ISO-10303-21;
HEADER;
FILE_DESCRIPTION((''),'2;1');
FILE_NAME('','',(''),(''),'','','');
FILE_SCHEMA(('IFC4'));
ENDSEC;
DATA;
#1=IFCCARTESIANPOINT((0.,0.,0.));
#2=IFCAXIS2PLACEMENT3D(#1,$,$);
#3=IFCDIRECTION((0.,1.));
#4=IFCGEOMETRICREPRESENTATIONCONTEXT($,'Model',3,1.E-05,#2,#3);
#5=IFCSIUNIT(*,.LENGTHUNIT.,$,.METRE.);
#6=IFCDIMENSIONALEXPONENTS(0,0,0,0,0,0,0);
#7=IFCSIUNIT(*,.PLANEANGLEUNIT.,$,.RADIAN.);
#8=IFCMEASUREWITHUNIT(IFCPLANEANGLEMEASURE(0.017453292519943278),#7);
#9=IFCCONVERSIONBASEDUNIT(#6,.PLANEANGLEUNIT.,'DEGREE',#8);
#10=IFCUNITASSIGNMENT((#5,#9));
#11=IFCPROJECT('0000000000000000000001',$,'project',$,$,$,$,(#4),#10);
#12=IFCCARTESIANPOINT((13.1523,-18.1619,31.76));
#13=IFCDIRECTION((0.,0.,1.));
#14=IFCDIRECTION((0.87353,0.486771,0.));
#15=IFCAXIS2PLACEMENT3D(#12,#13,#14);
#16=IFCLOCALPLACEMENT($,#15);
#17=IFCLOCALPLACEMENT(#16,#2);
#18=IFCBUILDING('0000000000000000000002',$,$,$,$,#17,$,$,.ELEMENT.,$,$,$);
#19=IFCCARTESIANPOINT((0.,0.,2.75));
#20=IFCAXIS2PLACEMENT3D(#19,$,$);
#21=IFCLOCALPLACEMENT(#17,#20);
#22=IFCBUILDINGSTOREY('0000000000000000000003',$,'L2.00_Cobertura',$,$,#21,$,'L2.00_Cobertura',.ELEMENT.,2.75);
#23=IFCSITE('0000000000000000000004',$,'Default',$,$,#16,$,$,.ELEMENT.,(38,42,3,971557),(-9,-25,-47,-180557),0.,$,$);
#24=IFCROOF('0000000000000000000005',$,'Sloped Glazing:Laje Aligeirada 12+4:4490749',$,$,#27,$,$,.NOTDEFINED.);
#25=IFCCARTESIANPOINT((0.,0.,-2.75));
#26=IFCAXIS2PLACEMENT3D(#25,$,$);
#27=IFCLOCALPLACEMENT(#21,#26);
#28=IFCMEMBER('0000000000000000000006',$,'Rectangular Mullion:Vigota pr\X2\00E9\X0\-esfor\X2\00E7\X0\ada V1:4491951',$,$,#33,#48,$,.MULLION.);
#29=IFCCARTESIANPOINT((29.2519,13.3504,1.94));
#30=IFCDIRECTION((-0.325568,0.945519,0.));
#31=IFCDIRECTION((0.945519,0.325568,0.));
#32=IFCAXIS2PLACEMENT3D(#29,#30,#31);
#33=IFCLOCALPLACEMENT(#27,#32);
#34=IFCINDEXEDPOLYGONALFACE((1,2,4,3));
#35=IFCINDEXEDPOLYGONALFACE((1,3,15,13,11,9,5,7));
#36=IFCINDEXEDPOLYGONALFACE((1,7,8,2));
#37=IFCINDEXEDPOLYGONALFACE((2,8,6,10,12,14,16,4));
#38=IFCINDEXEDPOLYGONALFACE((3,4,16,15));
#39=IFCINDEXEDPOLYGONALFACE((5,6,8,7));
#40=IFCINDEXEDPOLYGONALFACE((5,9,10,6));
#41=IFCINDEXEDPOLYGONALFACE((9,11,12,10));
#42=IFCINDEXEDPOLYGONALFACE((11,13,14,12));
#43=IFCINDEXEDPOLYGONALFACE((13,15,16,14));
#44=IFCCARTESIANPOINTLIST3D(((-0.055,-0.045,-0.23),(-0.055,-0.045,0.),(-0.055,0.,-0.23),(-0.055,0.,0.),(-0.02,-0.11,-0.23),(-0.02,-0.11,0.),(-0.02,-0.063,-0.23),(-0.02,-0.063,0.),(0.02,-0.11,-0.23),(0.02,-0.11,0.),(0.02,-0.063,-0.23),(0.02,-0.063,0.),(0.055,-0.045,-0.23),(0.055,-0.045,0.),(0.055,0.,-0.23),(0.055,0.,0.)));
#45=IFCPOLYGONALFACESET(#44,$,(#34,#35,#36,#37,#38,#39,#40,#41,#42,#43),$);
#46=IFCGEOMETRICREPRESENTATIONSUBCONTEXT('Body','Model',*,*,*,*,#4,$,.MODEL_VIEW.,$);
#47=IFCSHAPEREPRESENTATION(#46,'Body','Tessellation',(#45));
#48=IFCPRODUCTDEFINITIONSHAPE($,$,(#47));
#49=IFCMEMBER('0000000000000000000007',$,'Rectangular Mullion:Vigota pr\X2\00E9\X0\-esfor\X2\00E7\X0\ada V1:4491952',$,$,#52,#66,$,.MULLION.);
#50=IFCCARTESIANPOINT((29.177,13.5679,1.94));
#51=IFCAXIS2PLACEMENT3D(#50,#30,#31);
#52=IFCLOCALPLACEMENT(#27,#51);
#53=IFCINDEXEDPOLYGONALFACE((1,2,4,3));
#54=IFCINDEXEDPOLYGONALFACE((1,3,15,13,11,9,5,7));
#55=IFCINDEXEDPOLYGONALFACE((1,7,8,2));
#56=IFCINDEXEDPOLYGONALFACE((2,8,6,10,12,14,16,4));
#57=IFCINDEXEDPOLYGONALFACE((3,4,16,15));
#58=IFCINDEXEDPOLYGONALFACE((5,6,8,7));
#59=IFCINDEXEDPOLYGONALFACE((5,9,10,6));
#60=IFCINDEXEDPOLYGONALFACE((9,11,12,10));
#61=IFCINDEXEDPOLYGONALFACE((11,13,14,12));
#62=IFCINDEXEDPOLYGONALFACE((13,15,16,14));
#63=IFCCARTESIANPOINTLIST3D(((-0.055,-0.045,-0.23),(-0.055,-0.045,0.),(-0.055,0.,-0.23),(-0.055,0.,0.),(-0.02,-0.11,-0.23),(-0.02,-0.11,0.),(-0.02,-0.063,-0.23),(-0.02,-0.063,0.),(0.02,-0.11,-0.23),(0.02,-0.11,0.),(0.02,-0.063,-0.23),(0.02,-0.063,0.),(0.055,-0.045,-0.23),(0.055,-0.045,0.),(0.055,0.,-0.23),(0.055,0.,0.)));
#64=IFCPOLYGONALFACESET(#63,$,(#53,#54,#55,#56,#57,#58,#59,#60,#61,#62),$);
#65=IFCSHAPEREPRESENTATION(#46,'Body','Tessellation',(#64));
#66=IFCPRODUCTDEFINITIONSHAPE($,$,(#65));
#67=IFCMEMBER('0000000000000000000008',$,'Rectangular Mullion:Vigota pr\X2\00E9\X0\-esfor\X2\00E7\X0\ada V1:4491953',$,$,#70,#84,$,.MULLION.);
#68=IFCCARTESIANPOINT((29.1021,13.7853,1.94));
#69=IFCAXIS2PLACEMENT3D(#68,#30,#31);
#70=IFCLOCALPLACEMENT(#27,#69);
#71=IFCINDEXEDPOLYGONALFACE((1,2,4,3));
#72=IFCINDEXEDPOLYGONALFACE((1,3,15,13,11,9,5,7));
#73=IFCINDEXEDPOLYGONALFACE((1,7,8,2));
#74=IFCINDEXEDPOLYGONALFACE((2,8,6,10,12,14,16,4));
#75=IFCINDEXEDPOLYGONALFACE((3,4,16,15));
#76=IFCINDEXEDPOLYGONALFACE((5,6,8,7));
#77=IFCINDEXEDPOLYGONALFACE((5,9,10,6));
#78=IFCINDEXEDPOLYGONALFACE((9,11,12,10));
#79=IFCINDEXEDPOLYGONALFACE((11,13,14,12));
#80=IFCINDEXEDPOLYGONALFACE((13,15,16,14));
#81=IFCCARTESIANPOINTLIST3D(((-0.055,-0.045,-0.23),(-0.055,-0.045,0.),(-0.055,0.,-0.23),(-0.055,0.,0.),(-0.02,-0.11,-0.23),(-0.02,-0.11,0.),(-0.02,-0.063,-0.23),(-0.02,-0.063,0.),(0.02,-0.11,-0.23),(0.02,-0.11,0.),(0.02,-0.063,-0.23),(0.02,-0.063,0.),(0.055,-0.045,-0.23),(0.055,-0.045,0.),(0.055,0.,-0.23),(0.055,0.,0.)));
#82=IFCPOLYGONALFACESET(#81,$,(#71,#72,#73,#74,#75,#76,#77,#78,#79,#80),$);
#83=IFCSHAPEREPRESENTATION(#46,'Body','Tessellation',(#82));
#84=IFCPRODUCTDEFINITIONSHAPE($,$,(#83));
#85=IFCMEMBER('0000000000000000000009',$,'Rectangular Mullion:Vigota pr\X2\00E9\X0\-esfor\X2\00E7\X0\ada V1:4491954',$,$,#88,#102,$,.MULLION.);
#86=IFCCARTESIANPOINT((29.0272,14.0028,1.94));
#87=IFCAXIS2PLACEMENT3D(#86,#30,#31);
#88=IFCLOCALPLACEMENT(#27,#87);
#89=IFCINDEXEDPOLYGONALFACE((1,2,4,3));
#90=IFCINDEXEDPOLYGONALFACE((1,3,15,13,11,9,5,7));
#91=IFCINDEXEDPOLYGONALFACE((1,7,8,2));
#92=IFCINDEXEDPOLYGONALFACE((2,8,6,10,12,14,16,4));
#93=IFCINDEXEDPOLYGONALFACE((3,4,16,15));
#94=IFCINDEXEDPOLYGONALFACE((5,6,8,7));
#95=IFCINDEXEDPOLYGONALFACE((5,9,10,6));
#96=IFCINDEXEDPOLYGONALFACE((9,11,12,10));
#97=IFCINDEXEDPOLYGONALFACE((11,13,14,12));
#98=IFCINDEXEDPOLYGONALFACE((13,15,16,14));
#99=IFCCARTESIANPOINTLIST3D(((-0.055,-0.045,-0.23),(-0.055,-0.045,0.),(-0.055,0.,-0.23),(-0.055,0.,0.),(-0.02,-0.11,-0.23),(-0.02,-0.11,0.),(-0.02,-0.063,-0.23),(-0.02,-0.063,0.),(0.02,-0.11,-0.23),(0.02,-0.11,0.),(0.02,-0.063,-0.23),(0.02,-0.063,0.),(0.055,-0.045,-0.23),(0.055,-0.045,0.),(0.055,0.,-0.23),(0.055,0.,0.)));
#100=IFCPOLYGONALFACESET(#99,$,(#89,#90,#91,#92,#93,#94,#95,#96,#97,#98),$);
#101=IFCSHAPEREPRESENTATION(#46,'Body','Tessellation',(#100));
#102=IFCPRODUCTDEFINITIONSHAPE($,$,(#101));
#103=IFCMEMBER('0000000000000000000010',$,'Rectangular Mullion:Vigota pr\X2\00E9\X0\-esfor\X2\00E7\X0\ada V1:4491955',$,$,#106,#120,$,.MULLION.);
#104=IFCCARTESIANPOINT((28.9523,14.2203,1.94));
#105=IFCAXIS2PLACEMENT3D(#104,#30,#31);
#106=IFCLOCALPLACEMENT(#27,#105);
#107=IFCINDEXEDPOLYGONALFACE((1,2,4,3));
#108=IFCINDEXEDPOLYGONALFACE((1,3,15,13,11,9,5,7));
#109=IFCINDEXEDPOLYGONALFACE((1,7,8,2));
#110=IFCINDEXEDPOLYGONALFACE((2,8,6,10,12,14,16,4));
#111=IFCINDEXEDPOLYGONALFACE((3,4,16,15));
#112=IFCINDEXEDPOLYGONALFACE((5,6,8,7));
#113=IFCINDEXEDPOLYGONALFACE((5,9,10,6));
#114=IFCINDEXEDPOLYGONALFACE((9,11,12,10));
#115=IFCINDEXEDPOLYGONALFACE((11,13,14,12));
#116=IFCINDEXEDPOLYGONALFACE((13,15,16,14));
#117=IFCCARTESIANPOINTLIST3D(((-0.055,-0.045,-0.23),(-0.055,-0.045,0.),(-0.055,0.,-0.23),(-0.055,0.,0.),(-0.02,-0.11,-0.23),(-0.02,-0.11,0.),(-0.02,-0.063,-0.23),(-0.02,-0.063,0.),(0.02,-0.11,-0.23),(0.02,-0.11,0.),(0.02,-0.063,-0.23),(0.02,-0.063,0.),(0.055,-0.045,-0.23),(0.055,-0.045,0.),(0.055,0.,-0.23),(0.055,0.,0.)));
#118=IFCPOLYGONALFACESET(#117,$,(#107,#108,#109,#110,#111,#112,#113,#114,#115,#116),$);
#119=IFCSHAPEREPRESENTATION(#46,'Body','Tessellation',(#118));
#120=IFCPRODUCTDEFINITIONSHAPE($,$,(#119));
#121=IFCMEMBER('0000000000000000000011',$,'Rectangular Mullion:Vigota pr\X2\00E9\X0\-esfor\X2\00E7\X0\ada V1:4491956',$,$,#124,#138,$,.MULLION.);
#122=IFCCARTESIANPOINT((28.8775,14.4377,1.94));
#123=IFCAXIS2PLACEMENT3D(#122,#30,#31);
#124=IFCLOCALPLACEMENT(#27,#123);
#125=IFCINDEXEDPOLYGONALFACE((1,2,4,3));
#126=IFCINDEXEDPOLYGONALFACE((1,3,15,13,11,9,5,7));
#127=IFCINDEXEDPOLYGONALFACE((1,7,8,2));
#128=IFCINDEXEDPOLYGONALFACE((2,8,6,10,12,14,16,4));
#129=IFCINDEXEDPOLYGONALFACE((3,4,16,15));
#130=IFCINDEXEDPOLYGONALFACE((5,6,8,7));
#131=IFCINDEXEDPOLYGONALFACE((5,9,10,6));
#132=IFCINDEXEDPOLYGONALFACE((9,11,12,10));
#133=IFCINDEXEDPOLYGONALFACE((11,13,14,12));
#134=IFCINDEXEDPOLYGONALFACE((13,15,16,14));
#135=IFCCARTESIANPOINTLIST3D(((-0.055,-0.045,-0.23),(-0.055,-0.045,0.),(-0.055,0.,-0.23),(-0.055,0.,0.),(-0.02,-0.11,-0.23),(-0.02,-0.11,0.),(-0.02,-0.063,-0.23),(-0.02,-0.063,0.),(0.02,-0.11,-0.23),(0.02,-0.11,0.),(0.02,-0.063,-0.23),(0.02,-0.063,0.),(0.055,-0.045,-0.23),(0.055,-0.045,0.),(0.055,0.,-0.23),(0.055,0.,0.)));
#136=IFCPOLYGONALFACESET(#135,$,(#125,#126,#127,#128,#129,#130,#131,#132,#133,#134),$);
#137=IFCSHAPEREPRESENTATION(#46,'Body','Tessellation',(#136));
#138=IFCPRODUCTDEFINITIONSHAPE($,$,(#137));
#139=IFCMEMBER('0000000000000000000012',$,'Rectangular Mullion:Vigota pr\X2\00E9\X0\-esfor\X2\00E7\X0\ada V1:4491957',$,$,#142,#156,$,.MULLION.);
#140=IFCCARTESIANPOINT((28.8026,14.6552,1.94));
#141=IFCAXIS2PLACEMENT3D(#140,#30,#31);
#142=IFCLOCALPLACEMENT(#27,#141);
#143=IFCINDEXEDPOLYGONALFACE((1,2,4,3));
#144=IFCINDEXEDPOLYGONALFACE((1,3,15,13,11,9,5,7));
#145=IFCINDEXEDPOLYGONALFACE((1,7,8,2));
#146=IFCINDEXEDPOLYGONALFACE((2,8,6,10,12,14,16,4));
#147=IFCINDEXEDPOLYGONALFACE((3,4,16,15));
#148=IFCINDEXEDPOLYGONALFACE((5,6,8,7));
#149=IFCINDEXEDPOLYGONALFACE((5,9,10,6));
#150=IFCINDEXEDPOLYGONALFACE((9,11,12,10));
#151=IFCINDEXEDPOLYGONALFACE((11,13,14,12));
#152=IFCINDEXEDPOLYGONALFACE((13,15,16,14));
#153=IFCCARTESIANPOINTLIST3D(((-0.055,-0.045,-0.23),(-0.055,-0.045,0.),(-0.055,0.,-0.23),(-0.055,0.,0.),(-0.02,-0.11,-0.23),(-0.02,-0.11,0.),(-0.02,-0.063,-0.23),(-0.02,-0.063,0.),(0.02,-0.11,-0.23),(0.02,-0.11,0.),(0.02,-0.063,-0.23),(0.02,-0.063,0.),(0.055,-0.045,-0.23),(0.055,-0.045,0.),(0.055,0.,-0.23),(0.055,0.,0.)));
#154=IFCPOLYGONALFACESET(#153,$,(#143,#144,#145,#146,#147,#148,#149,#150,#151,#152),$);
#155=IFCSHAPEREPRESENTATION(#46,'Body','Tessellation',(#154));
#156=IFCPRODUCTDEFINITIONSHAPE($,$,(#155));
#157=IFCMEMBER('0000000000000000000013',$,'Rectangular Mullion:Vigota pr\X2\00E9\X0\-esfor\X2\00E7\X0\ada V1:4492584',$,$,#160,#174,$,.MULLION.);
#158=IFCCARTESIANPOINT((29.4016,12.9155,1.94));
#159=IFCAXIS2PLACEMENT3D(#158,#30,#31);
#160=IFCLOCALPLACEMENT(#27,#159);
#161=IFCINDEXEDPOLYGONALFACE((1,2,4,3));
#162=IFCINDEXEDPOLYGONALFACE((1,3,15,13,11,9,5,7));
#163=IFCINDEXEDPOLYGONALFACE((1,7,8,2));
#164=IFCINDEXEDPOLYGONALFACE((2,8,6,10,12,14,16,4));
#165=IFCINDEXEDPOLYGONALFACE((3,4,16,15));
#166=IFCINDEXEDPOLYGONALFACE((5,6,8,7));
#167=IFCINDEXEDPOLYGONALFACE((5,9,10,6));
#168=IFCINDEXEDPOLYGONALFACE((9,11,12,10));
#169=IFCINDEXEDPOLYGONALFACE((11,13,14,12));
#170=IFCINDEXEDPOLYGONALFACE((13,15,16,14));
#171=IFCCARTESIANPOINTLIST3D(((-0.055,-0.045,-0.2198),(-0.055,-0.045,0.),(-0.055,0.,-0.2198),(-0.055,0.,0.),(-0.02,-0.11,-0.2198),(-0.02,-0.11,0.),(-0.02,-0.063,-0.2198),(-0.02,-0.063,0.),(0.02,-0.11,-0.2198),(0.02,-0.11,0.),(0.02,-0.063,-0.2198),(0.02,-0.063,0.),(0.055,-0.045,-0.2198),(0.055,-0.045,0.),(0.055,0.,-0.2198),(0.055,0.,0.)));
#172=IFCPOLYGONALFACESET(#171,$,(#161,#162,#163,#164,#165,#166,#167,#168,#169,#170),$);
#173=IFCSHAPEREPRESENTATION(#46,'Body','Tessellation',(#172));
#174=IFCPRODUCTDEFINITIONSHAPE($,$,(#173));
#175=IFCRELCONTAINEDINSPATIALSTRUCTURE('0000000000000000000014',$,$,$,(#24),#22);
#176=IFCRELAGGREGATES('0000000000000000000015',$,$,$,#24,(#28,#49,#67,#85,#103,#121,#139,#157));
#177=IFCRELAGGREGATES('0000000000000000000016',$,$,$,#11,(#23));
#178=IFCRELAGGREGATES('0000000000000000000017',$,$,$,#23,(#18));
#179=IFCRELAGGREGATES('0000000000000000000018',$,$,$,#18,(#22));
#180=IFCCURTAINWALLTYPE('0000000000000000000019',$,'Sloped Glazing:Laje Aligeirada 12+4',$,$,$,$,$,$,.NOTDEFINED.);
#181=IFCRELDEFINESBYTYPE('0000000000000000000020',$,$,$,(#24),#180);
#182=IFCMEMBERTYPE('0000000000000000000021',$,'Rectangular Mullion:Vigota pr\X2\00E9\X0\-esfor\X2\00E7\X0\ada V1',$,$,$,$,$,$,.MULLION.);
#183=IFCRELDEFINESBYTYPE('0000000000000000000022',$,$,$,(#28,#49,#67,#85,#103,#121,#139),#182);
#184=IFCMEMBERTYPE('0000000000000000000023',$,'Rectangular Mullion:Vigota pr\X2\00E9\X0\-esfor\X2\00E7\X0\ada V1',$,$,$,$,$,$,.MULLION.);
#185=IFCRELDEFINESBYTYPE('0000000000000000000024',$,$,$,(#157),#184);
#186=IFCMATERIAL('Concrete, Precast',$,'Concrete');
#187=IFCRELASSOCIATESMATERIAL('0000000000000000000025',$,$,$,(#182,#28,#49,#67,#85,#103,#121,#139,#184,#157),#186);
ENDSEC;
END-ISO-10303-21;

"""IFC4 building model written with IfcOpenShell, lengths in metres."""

from ifc_helpers import new_model, entity, si_unit, converted_unit, direction, frame, origin, place, context, subcontext, project, spatial, indexed_curve, outline, extrude, source, transform, mapped, material, type_object, type_shapes, element, aggregate, save


model = new_model("IFC4")

# Units and contexts
model_context = context("Model", 3, precision=1e-05, world=origin(), true_north=direction((0.0, 1.0)))
body_context = subcontext(model_context, "Body", "Model", "MODEL_VIEW")
ifc_project = project(units=[si_unit("LENGTHUNIT", "METRE"), converted_unit("PLANEANGLEUNIT", "DEGREE", entity("IfcPlaneAngleMeasure", 0.017453292519943278), si_unit("PLANEANGLEUNIT", "RADIAN"), dimensions=[0, 0, 0, 0, 0, 0, 0])], contexts=[model_context])

# Site, building, storey
site_placement = place(None, frame((13.1523, -18.1619, 31.76), z_axis=(0.0, 0.0, 1.0), x_axis=(0.87353, 0.486771, 0.0)))
site = spatial("IfcSite", under=ifc_project, at=site_placement, Name="Default", CompositionType="ELEMENT", RefLatitude=(38, 42, 3, 971557), RefLongitude=(-9, -25, -47, -180557), RefElevation=0.0)
building_placement = place(site_placement, origin())
building = spatial("IfcBuilding", under=site, at=building_placement, CompositionType="ELEMENT")
storey_placement = place(building_placement, frame((0.0, 0.0, 2.75)))
storey = spatial("IfcBuildingStorey", under=building, at=storey_placement, Name="L2.00_Cobertura", LongName="L2.00_Cobertura", CompositionType="ELEMENT", Elevation=2.75)

# Roof, members
curtain_wall_type = type_object("IfcCurtainWallType", Name="Sloped Glazing:Laje Aligeirada 12+4", PredefinedType="NOTDEFINED")
roof_placement = place(storey_placement, frame((0.0, 0.0, -2.75)))
roof = element("IfcRoof", 1, at=roof_placement, inside=storey, type_object=curtain_wall_type, Name="Sloped Glazing:Laje Aligeirada 12+4:4490749", PredefinedType="NOTDEFINED")
ifc_material_1 = material(Name="Concrete, Precast", Category="Concrete")
member_type_1 = type_object("IfcMemberType", Name="Rectangular Mullion:Vigota pré-esforçada V1", PredefinedType="MULLION", material=ifc_material_1)
shared_shape_1 = source(origin(), body_context, "Body", "SweptSolid", [
    extrude(outline(indexed_curve([(-0.055, -0.0545), (0.055, -0.0545), (0.055, -0.0095), (0.02, 0.0085), (0.02, 0.0555), (-0.02, 0.0555), (-0.02, 0.0085), (-0.055, -0.0095), (-0.055, -0.0545)], self_intersect=False)), frame((0.0, -0.0545, -0.23), z_axis=(0.0, 0.0, 1.0), x_axis=(-1.0, 0.0, 0.0)), (0.0, 0.0, 1.0), 0.23),
])
type_shapes(member_type_1, [shared_shape_1])
member_1_placement = place(roof_placement, frame((29.2519, 13.3504, 1.94), z_axis=(-0.325568, 0.945519, 0.0), x_axis=(0.945519, 0.325568, 0.0)))
member_1 = element("IfcMember", 2, at=member_1_placement, type_object=member_type_1, material=ifc_material_1, Name="Rectangular Mullion:Vigota pré-esforçada V1:4491951", PredefinedType="MULLION", context=body_context, shape_type="MappedRepresentation", body=[
    mapped(shared_shape_1, transform((0.0, 0.0, 0.0), scale=1.0)),
])
member_2_placement = place(roof_placement, frame((29.177, 13.5679, 1.94), z_axis=(-0.325568, 0.945519, 0.0), x_axis=(0.945519, 0.325568, 0.0)))
member_2 = element("IfcMember", 3, at=member_2_placement, type_object=member_type_1, material=ifc_material_1, Name="Rectangular Mullion:Vigota pré-esforçada V1:4491952", PredefinedType="MULLION", context=body_context, shape_type="MappedRepresentation", body=[
    mapped(shared_shape_1, transform((0.0, 0.0, 0.0), scale=1.0)),
])
member_3_placement = place(roof_placement, frame((29.1021, 13.7853, 1.94), z_axis=(-0.325568, 0.945519, 0.0), x_axis=(0.945519, 0.325568, 0.0)))
member_3 = element("IfcMember", 4, at=member_3_placement, type_object=member_type_1, material=ifc_material_1, Name="Rectangular Mullion:Vigota pré-esforçada V1:4491953", PredefinedType="MULLION", context=body_context, shape_type="MappedRepresentation", body=[
    mapped(shared_shape_1, transform((0.0, 0.0, 0.0), scale=1.0)),
])
member_4_placement = place(roof_placement, frame((29.0272, 14.0028, 1.94), z_axis=(-0.325568, 0.945519, 0.0), x_axis=(0.945519, 0.325568, 0.0)))
member_4 = element("IfcMember", 5, at=member_4_placement, type_object=member_type_1, material=ifc_material_1, Name="Rectangular Mullion:Vigota pré-esforçada V1:4491954", PredefinedType="MULLION", context=body_context, shape_type="MappedRepresentation", body=[
    mapped(shared_shape_1, transform((0.0, 0.0, 0.0), scale=1.0)),
])
member_5_placement = place(roof_placement, frame((28.9523, 14.2203, 1.94), z_axis=(-0.325568, 0.945519, 0.0), x_axis=(0.945519, 0.325568, 0.0)))
member_5 = element("IfcMember", 6, at=member_5_placement, type_object=member_type_1, material=ifc_material_1, Name="Rectangular Mullion:Vigota pré-esforçada V1:4491955", PredefinedType="MULLION", context=body_context, shape_type="MappedRepresentation", body=[
    mapped(shared_shape_1, transform((0.0, 0.0, 0.0), scale=1.0)),
])
member_6_placement = place(roof_placement, frame((28.8775, 14.4377, 1.94), z_axis=(-0.325568, 0.945519, 0.0), x_axis=(0.945519, 0.325568, 0.0)))
member_6 = element("IfcMember", 7, at=member_6_placement, type_object=member_type_1, material=ifc_material_1, Name="Rectangular Mullion:Vigota pré-esforçada V1:4491956", PredefinedType="MULLION", context=body_context, shape_type="MappedRepresentation", body=[
    mapped(shared_shape_1, transform((0.0, 0.0, 0.0), scale=1.0)),
])
member_7_placement = place(roof_placement, frame((28.8026, 14.6552, 1.94), z_axis=(-0.325568, 0.945519, 0.0), x_axis=(0.945519, 0.325568, 0.0)))
member_7 = element("IfcMember", 8, at=member_7_placement, type_object=member_type_1, material=ifc_material_1, Name="Rectangular Mullion:Vigota pré-esforçada V1:4491957", PredefinedType="MULLION", context=body_context, shape_type="MappedRepresentation", body=[
    mapped(shared_shape_1, transform((0.0, 0.0, 0.0), scale=1.0)),
])
member_type_2 = type_object("IfcMemberType", Name="Rectangular Mullion:Vigota pré-esforçada V1", PredefinedType="MULLION", material=ifc_material_1)
shared_shape_2 = source(origin(), body_context, "Body", "SweptSolid", [
    extrude(outline(indexed_curve([(-0.055, -0.0545), (0.055, -0.0545), (0.055, -0.0095), (0.02, 0.0085), (0.02, 0.0555), (-0.02, 0.0555), (-0.02, 0.0085), (-0.055, -0.0095), (-0.055, -0.0545)], self_intersect=False)), frame((0.0, -0.0545, -0.2198), z_axis=(0.0, 0.0, 1.0), x_axis=(-1.0, 0.0, 0.0)), (0.0, 0.0, 1.0), 0.2198),
])
type_shapes(member_type_2, [shared_shape_2])
member_8_placement = place(roof_placement, frame((29.4016, 12.9155, 1.94), z_axis=(-0.325568, 0.945519, 0.0), x_axis=(0.945519, 0.325568, 0.0)))
member_8 = element("IfcMember", 9, at=member_8_placement, type_object=member_type_2, material=ifc_material_1, Name="Rectangular Mullion:Vigota pré-esforçada V1:4492584", PredefinedType="MULLION", context=body_context, shape_type="MappedRepresentation", body=[
    mapped(shared_shape_2, transform((0.0, 0.0, 0.0), scale=1.0)),
])
aggregate(roof, [member_1, member_2, member_3, member_4, member_5, member_6, member_7, member_8])

save(model, "model.ifc")
